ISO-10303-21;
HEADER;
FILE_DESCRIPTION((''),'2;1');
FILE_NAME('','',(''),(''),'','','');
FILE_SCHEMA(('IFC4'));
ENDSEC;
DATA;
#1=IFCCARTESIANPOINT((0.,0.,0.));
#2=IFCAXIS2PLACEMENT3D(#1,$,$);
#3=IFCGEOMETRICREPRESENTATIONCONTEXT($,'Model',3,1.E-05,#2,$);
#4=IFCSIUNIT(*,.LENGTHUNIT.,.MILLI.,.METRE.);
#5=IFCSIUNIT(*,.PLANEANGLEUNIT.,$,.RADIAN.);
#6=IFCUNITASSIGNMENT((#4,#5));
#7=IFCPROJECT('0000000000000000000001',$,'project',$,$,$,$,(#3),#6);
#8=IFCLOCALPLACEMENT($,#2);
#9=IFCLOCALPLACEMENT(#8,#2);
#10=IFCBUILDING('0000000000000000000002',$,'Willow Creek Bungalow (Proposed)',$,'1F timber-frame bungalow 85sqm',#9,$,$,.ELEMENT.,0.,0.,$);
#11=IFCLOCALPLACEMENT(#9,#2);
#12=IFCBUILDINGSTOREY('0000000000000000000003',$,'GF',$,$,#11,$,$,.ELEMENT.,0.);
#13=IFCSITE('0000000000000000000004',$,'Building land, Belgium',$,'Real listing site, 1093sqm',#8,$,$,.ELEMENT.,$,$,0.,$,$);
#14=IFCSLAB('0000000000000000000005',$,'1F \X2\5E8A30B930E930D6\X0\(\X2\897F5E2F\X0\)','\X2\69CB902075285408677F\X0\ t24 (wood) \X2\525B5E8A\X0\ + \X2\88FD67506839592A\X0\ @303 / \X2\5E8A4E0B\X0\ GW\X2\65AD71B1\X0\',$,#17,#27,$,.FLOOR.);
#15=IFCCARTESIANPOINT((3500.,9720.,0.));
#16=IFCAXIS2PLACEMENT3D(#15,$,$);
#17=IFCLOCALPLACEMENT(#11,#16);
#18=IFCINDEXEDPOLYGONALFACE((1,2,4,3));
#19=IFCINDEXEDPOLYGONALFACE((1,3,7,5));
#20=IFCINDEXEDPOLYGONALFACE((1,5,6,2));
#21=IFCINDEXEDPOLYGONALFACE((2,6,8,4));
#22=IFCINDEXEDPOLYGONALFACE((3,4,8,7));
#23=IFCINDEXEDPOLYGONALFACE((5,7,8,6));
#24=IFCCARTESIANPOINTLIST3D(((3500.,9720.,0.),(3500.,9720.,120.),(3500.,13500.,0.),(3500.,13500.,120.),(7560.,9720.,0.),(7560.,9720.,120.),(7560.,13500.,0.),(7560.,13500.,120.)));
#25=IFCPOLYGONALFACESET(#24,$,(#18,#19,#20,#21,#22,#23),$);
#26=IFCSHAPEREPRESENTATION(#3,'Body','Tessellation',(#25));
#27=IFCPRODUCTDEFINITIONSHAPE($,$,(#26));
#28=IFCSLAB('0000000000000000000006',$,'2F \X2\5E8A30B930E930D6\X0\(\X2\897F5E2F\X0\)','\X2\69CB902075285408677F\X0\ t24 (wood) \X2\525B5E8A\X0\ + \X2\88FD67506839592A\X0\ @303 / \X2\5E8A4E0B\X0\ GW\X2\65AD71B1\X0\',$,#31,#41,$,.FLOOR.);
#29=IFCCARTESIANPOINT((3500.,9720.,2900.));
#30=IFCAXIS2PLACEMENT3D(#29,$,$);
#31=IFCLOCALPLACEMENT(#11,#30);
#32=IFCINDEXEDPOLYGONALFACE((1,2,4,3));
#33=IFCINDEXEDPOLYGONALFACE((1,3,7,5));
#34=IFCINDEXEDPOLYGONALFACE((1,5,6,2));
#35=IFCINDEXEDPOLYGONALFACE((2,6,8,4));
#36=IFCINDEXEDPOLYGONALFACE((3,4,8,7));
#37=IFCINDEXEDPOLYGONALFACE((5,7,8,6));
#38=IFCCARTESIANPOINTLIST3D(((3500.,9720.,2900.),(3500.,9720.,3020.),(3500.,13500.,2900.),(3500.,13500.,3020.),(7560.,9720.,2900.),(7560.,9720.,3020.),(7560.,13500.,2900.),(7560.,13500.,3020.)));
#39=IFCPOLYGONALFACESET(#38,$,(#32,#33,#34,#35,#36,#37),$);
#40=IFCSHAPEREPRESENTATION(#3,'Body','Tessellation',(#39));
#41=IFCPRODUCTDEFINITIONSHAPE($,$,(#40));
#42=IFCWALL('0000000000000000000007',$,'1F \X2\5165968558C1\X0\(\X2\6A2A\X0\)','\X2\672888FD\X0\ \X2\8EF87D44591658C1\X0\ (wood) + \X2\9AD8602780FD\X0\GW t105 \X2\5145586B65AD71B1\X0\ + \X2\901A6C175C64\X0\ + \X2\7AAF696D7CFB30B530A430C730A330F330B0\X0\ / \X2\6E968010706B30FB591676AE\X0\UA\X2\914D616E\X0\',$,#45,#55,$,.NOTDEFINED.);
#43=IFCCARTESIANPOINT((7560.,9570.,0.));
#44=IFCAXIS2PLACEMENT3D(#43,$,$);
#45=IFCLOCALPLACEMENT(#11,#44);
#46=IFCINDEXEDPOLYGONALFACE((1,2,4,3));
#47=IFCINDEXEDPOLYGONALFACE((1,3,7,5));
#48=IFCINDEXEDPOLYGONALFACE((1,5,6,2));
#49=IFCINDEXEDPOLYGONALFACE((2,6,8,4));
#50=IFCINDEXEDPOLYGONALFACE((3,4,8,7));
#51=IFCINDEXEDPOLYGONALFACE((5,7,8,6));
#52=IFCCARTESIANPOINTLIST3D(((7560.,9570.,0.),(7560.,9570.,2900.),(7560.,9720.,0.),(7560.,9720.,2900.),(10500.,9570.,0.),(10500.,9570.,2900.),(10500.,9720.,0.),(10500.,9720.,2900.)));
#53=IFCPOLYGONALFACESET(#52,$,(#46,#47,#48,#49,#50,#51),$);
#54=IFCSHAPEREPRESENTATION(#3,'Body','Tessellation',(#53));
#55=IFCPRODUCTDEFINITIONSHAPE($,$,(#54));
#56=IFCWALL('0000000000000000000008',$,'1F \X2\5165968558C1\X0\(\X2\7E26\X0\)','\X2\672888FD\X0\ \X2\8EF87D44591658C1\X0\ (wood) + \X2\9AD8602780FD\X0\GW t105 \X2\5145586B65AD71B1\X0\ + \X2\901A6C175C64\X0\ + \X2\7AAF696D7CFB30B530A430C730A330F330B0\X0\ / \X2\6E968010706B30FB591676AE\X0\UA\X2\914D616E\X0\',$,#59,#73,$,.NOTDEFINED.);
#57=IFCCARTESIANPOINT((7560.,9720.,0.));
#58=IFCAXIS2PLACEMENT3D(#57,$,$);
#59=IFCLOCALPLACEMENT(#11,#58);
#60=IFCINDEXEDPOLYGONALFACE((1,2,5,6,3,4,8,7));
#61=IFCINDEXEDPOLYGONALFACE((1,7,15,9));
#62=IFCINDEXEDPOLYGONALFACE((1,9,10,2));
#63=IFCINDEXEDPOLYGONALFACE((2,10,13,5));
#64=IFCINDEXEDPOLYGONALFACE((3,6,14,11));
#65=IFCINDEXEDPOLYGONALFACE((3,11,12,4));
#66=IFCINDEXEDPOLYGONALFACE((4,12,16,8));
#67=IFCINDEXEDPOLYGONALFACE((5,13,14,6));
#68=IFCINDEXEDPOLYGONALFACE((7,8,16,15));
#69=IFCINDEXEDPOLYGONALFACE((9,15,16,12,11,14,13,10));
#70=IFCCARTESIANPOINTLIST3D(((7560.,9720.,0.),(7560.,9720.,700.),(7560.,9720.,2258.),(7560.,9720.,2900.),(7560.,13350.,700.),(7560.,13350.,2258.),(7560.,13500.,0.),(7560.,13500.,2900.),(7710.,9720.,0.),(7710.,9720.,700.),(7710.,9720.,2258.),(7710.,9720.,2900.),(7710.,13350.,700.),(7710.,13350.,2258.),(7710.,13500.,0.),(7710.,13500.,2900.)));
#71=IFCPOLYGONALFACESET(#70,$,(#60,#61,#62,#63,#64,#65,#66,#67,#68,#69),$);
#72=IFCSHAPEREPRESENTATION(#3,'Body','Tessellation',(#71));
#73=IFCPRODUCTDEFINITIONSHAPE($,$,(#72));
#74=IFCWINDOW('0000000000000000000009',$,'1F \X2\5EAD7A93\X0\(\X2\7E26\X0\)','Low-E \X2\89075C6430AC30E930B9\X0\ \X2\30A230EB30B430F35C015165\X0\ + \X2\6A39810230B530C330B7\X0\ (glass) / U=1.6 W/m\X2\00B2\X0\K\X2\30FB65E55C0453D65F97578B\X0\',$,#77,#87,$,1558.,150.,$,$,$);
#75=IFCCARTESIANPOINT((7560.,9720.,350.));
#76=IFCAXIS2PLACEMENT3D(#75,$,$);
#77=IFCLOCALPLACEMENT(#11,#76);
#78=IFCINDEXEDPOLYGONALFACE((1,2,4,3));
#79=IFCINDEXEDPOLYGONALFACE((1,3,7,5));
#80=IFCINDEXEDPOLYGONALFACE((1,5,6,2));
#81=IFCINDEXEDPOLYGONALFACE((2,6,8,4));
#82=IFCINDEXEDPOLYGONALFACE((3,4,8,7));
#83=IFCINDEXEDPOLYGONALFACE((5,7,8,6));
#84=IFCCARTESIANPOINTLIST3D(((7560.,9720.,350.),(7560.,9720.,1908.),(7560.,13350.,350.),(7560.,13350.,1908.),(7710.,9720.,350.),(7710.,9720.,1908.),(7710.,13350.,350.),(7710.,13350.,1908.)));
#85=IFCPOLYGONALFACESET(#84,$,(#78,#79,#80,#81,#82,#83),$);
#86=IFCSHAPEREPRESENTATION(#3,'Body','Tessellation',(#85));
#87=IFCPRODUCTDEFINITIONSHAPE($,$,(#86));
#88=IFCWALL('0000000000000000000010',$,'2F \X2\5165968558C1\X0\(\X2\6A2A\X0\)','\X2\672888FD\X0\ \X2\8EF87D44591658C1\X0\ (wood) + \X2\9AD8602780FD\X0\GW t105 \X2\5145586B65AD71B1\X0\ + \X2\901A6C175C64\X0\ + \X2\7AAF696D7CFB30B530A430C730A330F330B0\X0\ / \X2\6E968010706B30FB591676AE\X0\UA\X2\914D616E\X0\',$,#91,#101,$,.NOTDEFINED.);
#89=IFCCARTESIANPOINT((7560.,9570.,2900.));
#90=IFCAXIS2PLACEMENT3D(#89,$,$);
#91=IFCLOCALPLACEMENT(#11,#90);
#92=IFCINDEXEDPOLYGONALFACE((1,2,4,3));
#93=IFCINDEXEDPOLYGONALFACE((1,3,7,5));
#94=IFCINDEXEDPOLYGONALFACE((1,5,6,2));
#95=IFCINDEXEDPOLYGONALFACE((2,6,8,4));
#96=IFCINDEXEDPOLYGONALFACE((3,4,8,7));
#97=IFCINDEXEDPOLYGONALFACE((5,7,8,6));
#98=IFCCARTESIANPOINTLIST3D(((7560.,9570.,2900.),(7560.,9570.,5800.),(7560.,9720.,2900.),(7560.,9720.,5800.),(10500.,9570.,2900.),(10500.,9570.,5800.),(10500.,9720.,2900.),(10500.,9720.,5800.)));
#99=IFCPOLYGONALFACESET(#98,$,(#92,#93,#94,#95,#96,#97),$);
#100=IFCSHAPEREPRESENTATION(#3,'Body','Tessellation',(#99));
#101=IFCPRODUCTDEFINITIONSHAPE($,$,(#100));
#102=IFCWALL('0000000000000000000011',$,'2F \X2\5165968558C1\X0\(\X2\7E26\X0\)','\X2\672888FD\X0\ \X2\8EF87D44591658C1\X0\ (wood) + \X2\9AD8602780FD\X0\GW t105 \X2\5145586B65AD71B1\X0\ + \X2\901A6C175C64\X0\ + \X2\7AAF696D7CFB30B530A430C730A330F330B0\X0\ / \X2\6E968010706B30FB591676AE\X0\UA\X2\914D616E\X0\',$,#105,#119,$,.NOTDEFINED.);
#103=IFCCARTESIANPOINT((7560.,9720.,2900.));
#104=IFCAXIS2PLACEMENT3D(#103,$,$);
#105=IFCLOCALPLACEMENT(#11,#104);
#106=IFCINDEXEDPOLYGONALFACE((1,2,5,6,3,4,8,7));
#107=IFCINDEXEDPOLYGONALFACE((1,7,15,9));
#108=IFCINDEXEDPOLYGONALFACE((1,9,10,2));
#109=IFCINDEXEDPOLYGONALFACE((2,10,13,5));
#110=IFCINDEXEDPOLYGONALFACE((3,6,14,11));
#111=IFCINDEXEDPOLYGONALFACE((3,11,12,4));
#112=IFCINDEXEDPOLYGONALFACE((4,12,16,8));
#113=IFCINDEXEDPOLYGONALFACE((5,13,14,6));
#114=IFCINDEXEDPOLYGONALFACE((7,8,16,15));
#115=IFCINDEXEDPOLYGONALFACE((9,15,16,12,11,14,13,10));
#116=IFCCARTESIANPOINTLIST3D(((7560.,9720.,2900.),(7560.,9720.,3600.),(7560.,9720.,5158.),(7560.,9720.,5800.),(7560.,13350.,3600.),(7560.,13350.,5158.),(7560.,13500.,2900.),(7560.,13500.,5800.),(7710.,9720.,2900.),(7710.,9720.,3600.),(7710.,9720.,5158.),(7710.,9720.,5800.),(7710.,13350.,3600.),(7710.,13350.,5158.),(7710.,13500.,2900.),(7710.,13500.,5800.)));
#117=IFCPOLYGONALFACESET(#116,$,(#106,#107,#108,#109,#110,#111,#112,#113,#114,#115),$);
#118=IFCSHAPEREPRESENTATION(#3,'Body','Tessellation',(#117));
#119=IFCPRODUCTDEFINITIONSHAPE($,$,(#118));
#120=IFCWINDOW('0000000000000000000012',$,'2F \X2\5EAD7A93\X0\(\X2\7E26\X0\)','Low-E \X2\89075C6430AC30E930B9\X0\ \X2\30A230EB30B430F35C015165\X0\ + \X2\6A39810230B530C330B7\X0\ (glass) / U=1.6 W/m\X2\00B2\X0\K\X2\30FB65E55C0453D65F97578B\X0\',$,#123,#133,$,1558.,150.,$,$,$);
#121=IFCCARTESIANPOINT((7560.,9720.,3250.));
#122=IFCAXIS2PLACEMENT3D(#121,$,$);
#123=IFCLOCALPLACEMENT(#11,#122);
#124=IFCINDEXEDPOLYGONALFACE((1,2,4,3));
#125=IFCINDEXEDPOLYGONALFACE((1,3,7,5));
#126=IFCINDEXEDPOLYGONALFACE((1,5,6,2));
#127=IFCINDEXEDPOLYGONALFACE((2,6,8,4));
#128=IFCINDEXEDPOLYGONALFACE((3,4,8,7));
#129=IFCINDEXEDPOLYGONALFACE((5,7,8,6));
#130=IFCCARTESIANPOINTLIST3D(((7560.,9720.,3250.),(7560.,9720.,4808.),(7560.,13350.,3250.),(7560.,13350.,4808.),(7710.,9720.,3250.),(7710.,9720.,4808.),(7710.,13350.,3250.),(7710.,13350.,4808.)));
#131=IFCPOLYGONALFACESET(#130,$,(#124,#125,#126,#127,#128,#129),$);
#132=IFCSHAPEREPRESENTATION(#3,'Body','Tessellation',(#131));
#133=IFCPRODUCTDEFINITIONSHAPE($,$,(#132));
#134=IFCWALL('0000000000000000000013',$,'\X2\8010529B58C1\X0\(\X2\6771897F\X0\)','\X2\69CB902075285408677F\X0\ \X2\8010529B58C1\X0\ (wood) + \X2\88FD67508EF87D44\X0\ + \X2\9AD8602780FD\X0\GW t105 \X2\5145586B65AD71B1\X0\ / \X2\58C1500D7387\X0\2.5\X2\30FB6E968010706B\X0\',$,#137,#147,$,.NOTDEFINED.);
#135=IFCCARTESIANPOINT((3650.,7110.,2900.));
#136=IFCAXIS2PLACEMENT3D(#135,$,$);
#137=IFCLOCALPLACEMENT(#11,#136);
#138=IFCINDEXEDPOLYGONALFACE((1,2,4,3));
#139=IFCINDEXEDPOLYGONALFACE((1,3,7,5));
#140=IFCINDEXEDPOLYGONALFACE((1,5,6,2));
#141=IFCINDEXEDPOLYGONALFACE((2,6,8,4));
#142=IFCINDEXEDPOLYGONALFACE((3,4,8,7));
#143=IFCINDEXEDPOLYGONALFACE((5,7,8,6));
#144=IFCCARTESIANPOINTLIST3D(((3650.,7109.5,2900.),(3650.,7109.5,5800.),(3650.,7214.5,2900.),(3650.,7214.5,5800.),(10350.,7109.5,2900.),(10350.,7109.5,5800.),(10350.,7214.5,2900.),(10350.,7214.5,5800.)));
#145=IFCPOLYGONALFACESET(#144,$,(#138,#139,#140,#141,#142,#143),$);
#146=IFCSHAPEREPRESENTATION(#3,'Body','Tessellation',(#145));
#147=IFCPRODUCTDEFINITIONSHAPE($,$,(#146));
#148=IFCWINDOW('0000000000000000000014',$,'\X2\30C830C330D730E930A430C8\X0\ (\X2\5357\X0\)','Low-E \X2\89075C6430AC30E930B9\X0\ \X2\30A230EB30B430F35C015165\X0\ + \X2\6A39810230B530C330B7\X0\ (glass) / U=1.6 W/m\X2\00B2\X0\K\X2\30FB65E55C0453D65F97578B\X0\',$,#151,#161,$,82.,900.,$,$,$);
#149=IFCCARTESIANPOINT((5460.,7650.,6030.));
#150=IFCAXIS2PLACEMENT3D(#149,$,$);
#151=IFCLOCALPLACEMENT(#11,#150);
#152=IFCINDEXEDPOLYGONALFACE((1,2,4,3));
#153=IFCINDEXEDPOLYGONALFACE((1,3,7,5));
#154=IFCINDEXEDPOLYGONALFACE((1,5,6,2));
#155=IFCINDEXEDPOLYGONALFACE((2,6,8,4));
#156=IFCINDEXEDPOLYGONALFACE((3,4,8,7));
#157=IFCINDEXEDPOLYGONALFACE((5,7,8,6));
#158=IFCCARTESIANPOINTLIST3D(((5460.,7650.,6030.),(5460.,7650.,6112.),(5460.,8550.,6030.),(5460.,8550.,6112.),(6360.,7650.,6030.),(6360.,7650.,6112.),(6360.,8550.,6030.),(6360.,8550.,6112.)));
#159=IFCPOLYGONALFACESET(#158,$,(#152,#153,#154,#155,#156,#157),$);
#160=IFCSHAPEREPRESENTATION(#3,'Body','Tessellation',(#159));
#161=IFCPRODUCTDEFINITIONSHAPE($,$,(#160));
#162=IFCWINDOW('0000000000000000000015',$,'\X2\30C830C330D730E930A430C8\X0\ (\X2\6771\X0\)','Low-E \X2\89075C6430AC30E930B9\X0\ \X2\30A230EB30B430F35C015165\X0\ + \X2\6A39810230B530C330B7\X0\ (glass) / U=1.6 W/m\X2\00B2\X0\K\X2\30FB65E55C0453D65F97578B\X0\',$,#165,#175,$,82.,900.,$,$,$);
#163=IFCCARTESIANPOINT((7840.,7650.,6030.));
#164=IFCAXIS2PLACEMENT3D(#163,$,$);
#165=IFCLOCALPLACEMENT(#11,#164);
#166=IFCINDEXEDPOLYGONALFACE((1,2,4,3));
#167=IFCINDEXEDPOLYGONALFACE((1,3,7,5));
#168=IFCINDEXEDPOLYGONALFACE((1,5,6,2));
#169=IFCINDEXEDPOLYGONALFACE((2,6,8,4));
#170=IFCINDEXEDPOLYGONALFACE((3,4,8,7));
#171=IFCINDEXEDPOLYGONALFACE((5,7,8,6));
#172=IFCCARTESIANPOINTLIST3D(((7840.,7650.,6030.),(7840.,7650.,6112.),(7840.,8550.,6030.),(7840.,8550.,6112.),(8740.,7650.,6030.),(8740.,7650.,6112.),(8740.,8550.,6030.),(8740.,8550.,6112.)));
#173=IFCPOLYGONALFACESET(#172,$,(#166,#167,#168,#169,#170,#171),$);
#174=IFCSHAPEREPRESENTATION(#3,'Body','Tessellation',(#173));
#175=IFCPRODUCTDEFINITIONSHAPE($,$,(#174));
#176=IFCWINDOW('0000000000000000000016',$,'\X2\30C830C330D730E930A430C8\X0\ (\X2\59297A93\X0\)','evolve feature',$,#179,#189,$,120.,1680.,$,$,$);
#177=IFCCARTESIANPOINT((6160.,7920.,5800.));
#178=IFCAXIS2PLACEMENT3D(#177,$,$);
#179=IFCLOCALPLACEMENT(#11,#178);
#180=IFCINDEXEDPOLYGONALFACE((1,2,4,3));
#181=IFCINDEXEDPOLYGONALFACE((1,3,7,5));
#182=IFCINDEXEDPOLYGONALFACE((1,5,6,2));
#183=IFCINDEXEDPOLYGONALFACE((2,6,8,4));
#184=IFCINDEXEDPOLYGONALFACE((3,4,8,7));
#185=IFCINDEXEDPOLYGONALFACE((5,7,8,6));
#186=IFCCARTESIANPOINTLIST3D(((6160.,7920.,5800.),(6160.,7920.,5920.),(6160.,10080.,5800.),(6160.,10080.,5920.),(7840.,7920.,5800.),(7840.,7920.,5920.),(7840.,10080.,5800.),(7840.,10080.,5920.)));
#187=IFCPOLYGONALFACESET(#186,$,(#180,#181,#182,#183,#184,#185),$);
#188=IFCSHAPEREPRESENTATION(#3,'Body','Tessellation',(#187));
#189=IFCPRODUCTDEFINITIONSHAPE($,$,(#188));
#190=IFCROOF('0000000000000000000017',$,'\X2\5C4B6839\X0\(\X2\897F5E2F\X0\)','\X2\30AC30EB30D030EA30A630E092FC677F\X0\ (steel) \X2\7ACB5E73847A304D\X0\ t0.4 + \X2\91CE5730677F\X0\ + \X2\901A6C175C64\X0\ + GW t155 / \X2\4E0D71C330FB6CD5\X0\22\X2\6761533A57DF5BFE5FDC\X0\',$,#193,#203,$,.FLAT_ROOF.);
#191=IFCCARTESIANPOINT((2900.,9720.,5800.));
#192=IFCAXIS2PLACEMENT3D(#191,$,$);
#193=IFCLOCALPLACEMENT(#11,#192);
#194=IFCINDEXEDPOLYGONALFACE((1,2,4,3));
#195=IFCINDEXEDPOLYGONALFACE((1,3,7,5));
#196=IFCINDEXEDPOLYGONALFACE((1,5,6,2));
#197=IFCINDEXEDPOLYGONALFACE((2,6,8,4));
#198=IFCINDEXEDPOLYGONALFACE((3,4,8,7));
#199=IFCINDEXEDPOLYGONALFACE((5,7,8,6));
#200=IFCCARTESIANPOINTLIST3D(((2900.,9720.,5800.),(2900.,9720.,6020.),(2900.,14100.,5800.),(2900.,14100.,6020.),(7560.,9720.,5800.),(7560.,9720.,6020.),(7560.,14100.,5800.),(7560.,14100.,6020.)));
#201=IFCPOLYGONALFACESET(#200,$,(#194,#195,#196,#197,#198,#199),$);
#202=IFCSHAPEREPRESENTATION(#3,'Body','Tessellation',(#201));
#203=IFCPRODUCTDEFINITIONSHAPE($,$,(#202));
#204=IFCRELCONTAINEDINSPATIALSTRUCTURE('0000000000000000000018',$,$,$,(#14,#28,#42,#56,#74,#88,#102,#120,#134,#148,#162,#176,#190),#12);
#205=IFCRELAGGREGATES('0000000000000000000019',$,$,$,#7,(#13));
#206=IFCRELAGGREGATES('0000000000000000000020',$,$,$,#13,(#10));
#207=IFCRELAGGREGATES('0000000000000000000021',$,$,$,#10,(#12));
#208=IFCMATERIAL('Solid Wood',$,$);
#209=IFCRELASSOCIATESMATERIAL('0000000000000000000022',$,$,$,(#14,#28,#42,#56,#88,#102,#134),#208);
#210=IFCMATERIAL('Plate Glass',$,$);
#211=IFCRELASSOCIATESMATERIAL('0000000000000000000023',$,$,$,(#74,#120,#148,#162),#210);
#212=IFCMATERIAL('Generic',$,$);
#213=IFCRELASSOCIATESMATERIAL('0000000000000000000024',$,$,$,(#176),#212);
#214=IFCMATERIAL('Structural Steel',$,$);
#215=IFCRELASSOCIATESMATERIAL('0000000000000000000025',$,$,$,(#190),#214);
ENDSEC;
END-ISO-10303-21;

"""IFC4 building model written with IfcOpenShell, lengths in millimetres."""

from ifc_helpers import new_model, si_unit, frame, frame_2d, origin, place, context, project, spatial, rectangle, extrude, material, element, fill, save


model = new_model("IFC4")

# Units and contexts
model_context = context("Model", 3, precision=1e-05, world=origin())
ifc_project = project(units=[si_unit("LENGTHUNIT", "METRE", prefix="MILLI"), si_unit("PLANEANGLEUNIT", "RADIAN")], contexts=[model_context])

# Site, building, storey
site_placement = place(None, origin())
site = spatial("IfcSite", under=ifc_project, at=site_placement, Name="Building land, Belgium", ObjectType="Real listing site, 1093sqm", CompositionType="ELEMENT", RefElevation=0.0)
building_placement = place(site_placement, origin())
building = spatial("IfcBuilding", under=site, at=building_placement, Name="Willow Creek Bungalow (Proposed)", ObjectType="1F timber-frame bungalow 85sqm", CompositionType="ELEMENT", ElevationOfRefHeight=0.0, ElevationOfTerrain=0.0)
storey_placement = place(building_placement, origin())
storey = spatial("IfcBuildingStorey", under=building, at=storey_placement, Name="GF", CompositionType="ELEMENT", Elevation=0.0)

# Slabs
ifc_material_1 = material(Name="Solid Wood")
slab_1_placement = place(storey_placement, frame((3500.0, 9720.0, 0.0)))
element("IfcSlab", 1, at=slab_1_placement, inside=storey, material=ifc_material_1, Name="1F 床スラブ(西帯)", Description="構造用合板 t24 (wood) 剛床 + 製材根太 @303 / 床下 GW断熱", PredefinedType="FLOOR", context=model_context, shape_type="SweptSolid", body=[
    extrude(rectangle(XDim=4060.0, YDim=3780.0, at=frame_2d((2030.0, 1890.0))), frame((3500.0, 9720.0, 0.0)), (0.0, 0.0, 1.0), 120.0),
])
slab_2_placement = place(storey_placement, frame((3500.0, 9720.0, 2900.0)))
element("IfcSlab", 2, at=slab_2_placement, inside=storey, material=ifc_material_1, Name="2F 床スラブ(西帯)", Description="構造用合板 t24 (wood) 剛床 + 製材根太 @303 / 床下 GW断熱", PredefinedType="FLOOR", context=model_context, shape_type="SweptSolid", body=[
    extrude(rectangle(XDim=4060.0, YDim=3780.0, at=frame_2d((2030.0, 1890.0))), frame((3500.0, 9720.0, 2900.0)), (0.0, 0.0, 1.0), 120.0),
])

# Wall
wall_1_placement = place(storey_placement, frame((7560.0, 9570.0, 0.0)))
element("IfcWall", 3, at=wall_1_placement, inside=storey, material=ifc_material_1, Name="1F 入隅壁(横)", Description="木製 軸組外壁 (wood) + 高性能GW t105 充填断熱 + 通気層 + 窯業系サイディング / 準耐火・外皮UA配慮", PredefinedType="NOTDEFINED", context=model_context, shape_type="SweptSolid", body=[
    extrude(rectangle(XDim=2940.0, YDim=150.0, at=frame_2d((1470.0, 75.0))), frame((7560.0, 9570.0, 0.0)), (0.0, 0.0, 1.0), 2900.0),
])

# Wall, opening, window
wall_2_placement = place(storey_placement, frame((7560.0, 9720.0, 0.0)))
wall_2 = element("IfcWall", 4, at=wall_2_placement, inside=storey, material=ifc_material_1, Name="1F 入隅壁(縦)", Description="木製 軸組外壁 (wood) + 高性能GW t105 充填断熱 + 通気層 + 窯業系サイディング / 準耐火・外皮UA配慮", PredefinedType="NOTDEFINED", context=model_context, shape_type="SweptSolid", body=[
    extrude(rectangle(XDim=150.0, YDim=3780.0, at=frame_2d((75.0, 1890.0))), frame((7560.0, 9720.0, 0.0)), (0.0, 0.0, 1.0), 2900.0),
])
opening_1_placement = place(storey_placement, frame((7560.0, 9720.0, 350.0)))
opening_1 = element("IfcOpeningElement", 5, at=opening_1_placement, cuts=wall_2, PredefinedType="NOTDEFINED", context=model_context, shape_type="SweptSolid", body=[
    extrude(rectangle(XDim=150.0, YDim=3630.0, at=frame_2d((75.0, 1815.0))), frame((7560.0, 9720.0, 350.0)), (0.0, 0.0, 1.0), 1558.0),
])
ifc_material_2 = material(Name="Plate Glass")
window_1_placement = place(storey_placement, frame((7560.0, 9720.0, 350.0)))
window_1 = element("IfcWindow", 6, at=window_1_placement, inside=storey, material=ifc_material_2, Name="1F 庭窓(縦)", Description="Low-E 複層ガラス アルゴン封入 + 樹脂サッシ (glass) / U=1.6 W/m²K・日射取得型", OverallHeight=1558.0, OverallWidth=150.0, context=model_context, shape_type="SweptSolid", body=[
    extrude(rectangle(XDim=150.0, YDim=3630.0, at=frame_2d((75.0, 1815.0))), frame((7560.0, 9720.0, 350.0)), (0.0, 0.0, 1.0), 1558.0),
])
fill(opening_1, window_1)

# Wall
wall_3_placement = place(storey_placement, frame((7560.0, 9570.0, 2900.0)))
element("IfcWall", 7, at=wall_3_placement, inside=storey, material=ifc_material_1, Name="2F 入隅壁(横)", Description="木製 軸組外壁 (wood) + 高性能GW t105 充填断熱 + 通気層 + 窯業系サイディング / 準耐火・外皮UA配慮", PredefinedType="NOTDEFINED", context=model_context, shape_type="SweptSolid", body=[
    extrude(rectangle(XDim=2940.0, YDim=150.0, at=frame_2d((1470.0, 75.0))), frame((7560.0, 9570.0, 2900.0)), (0.0, 0.0, 1.0), 2900.0),
])

# Wall, opening, window
wall_4_placement = place(storey_placement, frame((7560.0, 9720.0, 2900.0)))
wall_4 = element("IfcWall", 8, at=wall_4_placement, inside=storey, material=ifc_material_1, Name="2F 入隅壁(縦)", Description="木製 軸組外壁 (wood) + 高性能GW t105 充填断熱 + 通気層 + 窯業系サイディング / 準耐火・外皮UA配慮", PredefinedType="NOTDEFINED", context=model_context, shape_type="SweptSolid", body=[
    extrude(rectangle(XDim=150.0, YDim=3780.0, at=frame_2d((75.0, 1890.0))), frame((7560.0, 9720.0, 2900.0)), (0.0, 0.0, 1.0), 2900.0),
])
opening_2_placement = place(storey_placement, frame((7560.0, 9720.0, 3250.0)))
opening_2 = element("IfcOpeningElement", 9, at=opening_2_placement, cuts=wall_4, PredefinedType="NOTDEFINED", context=model_context, shape_type="SweptSolid", body=[
    extrude(rectangle(XDim=150.0, YDim=3630.0, at=frame_2d((75.0, 1815.0))), frame((7560.0, 9720.0, 3250.0)), (0.0, 0.0, 1.0), 1558.0),
])
window_2_placement = place(storey_placement, frame((7560.0, 9720.0, 3250.0)))
window_2 = element("IfcWindow", 10, at=window_2_placement, inside=storey, material=ifc_material_2, Name="2F 庭窓(縦)", Description="Low-E 複層ガラス アルゴン封入 + 樹脂サッシ (glass) / U=1.6 W/m²K・日射取得型", OverallHeight=1558.0, OverallWidth=150.0, context=model_context, shape_type="SweptSolid", body=[
    extrude(rectangle(XDim=150.0, YDim=3630.0, at=frame_2d((75.0, 1815.0))), frame((7560.0, 9720.0, 3250.0)), (0.0, 0.0, 1.0), 1558.0),
])
fill(opening_2, window_2)

# Wall
wall_5_placement = place(storey_placement, frame((3650.0, 7110.0, 2900.0)))
element("IfcWall", 11, at=wall_5_placement, inside=storey, material=ifc_material_1, Name="耐力壁(東西)", Description="構造用合板 耐力壁 (wood) + 製材軸組 + 高性能GW t105 充填断熱 / 壁倍率2.5・準耐火", PredefinedType="NOTDEFINED", context=model_context, shape_type="SweptSolid", body=[
    extrude(rectangle(XDim=6700.0, YDim=105.0, at=frame_2d((3350.0, 52.0))), frame((3650.0, 7110.0, 2900.0)), (0.0, 0.0, 1.0), 2900.0),
])

# Windows
window_3_placement = place(storey_placement, frame((5460.0, 7650.0, 6030.0)))
element("IfcWindow", 12, at=window_3_placement, inside=storey, material=ifc_material_2, Name="トップライト (南)", Description="Low-E 複層ガラス アルゴン封入 + 樹脂サッシ (glass) / U=1.6 W/m²K・日射取得型", OverallHeight=82.0, OverallWidth=900.0, context=model_context, shape_type="SweptSolid", body=[
    extrude(rectangle(XDim=900.0, YDim=900.0, at=frame_2d((450.0, 450.0))), frame((5460.0, 7650.0, 6030.0)), (0.0, 0.0, 1.0), 82.0),
])
window_4_placement = place(storey_placement, frame((7840.0, 7650.0, 6030.0)))
element("IfcWindow", 13, at=window_4_placement, inside=storey, material=ifc_material_2, Name="トップライト (東)", Description="Low-E 複層ガラス アルゴン封入 + 樹脂サッシ (glass) / U=1.6 W/m²K・日射取得型", OverallHeight=82.0, OverallWidth=900.0, context=model_context, shape_type="SweptSolid", body=[
    extrude(rectangle(XDim=900.0, YDim=900.0, at=frame_2d((450.0, 450.0))), frame((7840.0, 7650.0, 6030.0)), (0.0, 0.0, 1.0), 82.0),
])
ifc_material_3 = material(Name="Generic")
window_5_placement = place(storey_placement, frame((6160.0, 7920.0, 5800.0)))
element("IfcWindow", 14, at=window_5_placement, inside=storey, material=ifc_material_3, Name="トップライト (天窓)", Description="evolve feature", OverallHeight=120.0, OverallWidth=1680.0, context=model_context, shape_type="SweptSolid", body=[
    extrude(rectangle(XDim=1680.0, YDim=2160.0, at=frame_2d((840.0, 1080.0))), frame((6160.0, 7920.0, 5800.0)), (0.0, 0.0, 1.0), 120.0),
])

# Roof
ifc_material_4 = material(Name="Structural Steel")
for number, where, name in (
    (15, (2900.0, 9720.0, 5800.0), "屋根(西帯)"),
):
    element("IfcRoof", number, at=place(storey_placement, frame(where)), inside=storey, material=ifc_material_4, Name=name, Description="ガルバリウム鋼板 (steel) 立平葺き t0.4 + 野地板 + 通気層 + GW t155 / 不燃・法22条区域対応", PredefinedType="FLAT_ROOF", context=model_context, shape_type="SweptSolid", body=[
        extrude(rectangle(XDim=4660.0, YDim=4380.0, at=frame_2d((2330.0, 2190.0))), frame((2900.0, 9720.0, 5800.0)), (0.0, 0.0, 1.0), 220.0),
    ])

save(model, "model.ifc")
